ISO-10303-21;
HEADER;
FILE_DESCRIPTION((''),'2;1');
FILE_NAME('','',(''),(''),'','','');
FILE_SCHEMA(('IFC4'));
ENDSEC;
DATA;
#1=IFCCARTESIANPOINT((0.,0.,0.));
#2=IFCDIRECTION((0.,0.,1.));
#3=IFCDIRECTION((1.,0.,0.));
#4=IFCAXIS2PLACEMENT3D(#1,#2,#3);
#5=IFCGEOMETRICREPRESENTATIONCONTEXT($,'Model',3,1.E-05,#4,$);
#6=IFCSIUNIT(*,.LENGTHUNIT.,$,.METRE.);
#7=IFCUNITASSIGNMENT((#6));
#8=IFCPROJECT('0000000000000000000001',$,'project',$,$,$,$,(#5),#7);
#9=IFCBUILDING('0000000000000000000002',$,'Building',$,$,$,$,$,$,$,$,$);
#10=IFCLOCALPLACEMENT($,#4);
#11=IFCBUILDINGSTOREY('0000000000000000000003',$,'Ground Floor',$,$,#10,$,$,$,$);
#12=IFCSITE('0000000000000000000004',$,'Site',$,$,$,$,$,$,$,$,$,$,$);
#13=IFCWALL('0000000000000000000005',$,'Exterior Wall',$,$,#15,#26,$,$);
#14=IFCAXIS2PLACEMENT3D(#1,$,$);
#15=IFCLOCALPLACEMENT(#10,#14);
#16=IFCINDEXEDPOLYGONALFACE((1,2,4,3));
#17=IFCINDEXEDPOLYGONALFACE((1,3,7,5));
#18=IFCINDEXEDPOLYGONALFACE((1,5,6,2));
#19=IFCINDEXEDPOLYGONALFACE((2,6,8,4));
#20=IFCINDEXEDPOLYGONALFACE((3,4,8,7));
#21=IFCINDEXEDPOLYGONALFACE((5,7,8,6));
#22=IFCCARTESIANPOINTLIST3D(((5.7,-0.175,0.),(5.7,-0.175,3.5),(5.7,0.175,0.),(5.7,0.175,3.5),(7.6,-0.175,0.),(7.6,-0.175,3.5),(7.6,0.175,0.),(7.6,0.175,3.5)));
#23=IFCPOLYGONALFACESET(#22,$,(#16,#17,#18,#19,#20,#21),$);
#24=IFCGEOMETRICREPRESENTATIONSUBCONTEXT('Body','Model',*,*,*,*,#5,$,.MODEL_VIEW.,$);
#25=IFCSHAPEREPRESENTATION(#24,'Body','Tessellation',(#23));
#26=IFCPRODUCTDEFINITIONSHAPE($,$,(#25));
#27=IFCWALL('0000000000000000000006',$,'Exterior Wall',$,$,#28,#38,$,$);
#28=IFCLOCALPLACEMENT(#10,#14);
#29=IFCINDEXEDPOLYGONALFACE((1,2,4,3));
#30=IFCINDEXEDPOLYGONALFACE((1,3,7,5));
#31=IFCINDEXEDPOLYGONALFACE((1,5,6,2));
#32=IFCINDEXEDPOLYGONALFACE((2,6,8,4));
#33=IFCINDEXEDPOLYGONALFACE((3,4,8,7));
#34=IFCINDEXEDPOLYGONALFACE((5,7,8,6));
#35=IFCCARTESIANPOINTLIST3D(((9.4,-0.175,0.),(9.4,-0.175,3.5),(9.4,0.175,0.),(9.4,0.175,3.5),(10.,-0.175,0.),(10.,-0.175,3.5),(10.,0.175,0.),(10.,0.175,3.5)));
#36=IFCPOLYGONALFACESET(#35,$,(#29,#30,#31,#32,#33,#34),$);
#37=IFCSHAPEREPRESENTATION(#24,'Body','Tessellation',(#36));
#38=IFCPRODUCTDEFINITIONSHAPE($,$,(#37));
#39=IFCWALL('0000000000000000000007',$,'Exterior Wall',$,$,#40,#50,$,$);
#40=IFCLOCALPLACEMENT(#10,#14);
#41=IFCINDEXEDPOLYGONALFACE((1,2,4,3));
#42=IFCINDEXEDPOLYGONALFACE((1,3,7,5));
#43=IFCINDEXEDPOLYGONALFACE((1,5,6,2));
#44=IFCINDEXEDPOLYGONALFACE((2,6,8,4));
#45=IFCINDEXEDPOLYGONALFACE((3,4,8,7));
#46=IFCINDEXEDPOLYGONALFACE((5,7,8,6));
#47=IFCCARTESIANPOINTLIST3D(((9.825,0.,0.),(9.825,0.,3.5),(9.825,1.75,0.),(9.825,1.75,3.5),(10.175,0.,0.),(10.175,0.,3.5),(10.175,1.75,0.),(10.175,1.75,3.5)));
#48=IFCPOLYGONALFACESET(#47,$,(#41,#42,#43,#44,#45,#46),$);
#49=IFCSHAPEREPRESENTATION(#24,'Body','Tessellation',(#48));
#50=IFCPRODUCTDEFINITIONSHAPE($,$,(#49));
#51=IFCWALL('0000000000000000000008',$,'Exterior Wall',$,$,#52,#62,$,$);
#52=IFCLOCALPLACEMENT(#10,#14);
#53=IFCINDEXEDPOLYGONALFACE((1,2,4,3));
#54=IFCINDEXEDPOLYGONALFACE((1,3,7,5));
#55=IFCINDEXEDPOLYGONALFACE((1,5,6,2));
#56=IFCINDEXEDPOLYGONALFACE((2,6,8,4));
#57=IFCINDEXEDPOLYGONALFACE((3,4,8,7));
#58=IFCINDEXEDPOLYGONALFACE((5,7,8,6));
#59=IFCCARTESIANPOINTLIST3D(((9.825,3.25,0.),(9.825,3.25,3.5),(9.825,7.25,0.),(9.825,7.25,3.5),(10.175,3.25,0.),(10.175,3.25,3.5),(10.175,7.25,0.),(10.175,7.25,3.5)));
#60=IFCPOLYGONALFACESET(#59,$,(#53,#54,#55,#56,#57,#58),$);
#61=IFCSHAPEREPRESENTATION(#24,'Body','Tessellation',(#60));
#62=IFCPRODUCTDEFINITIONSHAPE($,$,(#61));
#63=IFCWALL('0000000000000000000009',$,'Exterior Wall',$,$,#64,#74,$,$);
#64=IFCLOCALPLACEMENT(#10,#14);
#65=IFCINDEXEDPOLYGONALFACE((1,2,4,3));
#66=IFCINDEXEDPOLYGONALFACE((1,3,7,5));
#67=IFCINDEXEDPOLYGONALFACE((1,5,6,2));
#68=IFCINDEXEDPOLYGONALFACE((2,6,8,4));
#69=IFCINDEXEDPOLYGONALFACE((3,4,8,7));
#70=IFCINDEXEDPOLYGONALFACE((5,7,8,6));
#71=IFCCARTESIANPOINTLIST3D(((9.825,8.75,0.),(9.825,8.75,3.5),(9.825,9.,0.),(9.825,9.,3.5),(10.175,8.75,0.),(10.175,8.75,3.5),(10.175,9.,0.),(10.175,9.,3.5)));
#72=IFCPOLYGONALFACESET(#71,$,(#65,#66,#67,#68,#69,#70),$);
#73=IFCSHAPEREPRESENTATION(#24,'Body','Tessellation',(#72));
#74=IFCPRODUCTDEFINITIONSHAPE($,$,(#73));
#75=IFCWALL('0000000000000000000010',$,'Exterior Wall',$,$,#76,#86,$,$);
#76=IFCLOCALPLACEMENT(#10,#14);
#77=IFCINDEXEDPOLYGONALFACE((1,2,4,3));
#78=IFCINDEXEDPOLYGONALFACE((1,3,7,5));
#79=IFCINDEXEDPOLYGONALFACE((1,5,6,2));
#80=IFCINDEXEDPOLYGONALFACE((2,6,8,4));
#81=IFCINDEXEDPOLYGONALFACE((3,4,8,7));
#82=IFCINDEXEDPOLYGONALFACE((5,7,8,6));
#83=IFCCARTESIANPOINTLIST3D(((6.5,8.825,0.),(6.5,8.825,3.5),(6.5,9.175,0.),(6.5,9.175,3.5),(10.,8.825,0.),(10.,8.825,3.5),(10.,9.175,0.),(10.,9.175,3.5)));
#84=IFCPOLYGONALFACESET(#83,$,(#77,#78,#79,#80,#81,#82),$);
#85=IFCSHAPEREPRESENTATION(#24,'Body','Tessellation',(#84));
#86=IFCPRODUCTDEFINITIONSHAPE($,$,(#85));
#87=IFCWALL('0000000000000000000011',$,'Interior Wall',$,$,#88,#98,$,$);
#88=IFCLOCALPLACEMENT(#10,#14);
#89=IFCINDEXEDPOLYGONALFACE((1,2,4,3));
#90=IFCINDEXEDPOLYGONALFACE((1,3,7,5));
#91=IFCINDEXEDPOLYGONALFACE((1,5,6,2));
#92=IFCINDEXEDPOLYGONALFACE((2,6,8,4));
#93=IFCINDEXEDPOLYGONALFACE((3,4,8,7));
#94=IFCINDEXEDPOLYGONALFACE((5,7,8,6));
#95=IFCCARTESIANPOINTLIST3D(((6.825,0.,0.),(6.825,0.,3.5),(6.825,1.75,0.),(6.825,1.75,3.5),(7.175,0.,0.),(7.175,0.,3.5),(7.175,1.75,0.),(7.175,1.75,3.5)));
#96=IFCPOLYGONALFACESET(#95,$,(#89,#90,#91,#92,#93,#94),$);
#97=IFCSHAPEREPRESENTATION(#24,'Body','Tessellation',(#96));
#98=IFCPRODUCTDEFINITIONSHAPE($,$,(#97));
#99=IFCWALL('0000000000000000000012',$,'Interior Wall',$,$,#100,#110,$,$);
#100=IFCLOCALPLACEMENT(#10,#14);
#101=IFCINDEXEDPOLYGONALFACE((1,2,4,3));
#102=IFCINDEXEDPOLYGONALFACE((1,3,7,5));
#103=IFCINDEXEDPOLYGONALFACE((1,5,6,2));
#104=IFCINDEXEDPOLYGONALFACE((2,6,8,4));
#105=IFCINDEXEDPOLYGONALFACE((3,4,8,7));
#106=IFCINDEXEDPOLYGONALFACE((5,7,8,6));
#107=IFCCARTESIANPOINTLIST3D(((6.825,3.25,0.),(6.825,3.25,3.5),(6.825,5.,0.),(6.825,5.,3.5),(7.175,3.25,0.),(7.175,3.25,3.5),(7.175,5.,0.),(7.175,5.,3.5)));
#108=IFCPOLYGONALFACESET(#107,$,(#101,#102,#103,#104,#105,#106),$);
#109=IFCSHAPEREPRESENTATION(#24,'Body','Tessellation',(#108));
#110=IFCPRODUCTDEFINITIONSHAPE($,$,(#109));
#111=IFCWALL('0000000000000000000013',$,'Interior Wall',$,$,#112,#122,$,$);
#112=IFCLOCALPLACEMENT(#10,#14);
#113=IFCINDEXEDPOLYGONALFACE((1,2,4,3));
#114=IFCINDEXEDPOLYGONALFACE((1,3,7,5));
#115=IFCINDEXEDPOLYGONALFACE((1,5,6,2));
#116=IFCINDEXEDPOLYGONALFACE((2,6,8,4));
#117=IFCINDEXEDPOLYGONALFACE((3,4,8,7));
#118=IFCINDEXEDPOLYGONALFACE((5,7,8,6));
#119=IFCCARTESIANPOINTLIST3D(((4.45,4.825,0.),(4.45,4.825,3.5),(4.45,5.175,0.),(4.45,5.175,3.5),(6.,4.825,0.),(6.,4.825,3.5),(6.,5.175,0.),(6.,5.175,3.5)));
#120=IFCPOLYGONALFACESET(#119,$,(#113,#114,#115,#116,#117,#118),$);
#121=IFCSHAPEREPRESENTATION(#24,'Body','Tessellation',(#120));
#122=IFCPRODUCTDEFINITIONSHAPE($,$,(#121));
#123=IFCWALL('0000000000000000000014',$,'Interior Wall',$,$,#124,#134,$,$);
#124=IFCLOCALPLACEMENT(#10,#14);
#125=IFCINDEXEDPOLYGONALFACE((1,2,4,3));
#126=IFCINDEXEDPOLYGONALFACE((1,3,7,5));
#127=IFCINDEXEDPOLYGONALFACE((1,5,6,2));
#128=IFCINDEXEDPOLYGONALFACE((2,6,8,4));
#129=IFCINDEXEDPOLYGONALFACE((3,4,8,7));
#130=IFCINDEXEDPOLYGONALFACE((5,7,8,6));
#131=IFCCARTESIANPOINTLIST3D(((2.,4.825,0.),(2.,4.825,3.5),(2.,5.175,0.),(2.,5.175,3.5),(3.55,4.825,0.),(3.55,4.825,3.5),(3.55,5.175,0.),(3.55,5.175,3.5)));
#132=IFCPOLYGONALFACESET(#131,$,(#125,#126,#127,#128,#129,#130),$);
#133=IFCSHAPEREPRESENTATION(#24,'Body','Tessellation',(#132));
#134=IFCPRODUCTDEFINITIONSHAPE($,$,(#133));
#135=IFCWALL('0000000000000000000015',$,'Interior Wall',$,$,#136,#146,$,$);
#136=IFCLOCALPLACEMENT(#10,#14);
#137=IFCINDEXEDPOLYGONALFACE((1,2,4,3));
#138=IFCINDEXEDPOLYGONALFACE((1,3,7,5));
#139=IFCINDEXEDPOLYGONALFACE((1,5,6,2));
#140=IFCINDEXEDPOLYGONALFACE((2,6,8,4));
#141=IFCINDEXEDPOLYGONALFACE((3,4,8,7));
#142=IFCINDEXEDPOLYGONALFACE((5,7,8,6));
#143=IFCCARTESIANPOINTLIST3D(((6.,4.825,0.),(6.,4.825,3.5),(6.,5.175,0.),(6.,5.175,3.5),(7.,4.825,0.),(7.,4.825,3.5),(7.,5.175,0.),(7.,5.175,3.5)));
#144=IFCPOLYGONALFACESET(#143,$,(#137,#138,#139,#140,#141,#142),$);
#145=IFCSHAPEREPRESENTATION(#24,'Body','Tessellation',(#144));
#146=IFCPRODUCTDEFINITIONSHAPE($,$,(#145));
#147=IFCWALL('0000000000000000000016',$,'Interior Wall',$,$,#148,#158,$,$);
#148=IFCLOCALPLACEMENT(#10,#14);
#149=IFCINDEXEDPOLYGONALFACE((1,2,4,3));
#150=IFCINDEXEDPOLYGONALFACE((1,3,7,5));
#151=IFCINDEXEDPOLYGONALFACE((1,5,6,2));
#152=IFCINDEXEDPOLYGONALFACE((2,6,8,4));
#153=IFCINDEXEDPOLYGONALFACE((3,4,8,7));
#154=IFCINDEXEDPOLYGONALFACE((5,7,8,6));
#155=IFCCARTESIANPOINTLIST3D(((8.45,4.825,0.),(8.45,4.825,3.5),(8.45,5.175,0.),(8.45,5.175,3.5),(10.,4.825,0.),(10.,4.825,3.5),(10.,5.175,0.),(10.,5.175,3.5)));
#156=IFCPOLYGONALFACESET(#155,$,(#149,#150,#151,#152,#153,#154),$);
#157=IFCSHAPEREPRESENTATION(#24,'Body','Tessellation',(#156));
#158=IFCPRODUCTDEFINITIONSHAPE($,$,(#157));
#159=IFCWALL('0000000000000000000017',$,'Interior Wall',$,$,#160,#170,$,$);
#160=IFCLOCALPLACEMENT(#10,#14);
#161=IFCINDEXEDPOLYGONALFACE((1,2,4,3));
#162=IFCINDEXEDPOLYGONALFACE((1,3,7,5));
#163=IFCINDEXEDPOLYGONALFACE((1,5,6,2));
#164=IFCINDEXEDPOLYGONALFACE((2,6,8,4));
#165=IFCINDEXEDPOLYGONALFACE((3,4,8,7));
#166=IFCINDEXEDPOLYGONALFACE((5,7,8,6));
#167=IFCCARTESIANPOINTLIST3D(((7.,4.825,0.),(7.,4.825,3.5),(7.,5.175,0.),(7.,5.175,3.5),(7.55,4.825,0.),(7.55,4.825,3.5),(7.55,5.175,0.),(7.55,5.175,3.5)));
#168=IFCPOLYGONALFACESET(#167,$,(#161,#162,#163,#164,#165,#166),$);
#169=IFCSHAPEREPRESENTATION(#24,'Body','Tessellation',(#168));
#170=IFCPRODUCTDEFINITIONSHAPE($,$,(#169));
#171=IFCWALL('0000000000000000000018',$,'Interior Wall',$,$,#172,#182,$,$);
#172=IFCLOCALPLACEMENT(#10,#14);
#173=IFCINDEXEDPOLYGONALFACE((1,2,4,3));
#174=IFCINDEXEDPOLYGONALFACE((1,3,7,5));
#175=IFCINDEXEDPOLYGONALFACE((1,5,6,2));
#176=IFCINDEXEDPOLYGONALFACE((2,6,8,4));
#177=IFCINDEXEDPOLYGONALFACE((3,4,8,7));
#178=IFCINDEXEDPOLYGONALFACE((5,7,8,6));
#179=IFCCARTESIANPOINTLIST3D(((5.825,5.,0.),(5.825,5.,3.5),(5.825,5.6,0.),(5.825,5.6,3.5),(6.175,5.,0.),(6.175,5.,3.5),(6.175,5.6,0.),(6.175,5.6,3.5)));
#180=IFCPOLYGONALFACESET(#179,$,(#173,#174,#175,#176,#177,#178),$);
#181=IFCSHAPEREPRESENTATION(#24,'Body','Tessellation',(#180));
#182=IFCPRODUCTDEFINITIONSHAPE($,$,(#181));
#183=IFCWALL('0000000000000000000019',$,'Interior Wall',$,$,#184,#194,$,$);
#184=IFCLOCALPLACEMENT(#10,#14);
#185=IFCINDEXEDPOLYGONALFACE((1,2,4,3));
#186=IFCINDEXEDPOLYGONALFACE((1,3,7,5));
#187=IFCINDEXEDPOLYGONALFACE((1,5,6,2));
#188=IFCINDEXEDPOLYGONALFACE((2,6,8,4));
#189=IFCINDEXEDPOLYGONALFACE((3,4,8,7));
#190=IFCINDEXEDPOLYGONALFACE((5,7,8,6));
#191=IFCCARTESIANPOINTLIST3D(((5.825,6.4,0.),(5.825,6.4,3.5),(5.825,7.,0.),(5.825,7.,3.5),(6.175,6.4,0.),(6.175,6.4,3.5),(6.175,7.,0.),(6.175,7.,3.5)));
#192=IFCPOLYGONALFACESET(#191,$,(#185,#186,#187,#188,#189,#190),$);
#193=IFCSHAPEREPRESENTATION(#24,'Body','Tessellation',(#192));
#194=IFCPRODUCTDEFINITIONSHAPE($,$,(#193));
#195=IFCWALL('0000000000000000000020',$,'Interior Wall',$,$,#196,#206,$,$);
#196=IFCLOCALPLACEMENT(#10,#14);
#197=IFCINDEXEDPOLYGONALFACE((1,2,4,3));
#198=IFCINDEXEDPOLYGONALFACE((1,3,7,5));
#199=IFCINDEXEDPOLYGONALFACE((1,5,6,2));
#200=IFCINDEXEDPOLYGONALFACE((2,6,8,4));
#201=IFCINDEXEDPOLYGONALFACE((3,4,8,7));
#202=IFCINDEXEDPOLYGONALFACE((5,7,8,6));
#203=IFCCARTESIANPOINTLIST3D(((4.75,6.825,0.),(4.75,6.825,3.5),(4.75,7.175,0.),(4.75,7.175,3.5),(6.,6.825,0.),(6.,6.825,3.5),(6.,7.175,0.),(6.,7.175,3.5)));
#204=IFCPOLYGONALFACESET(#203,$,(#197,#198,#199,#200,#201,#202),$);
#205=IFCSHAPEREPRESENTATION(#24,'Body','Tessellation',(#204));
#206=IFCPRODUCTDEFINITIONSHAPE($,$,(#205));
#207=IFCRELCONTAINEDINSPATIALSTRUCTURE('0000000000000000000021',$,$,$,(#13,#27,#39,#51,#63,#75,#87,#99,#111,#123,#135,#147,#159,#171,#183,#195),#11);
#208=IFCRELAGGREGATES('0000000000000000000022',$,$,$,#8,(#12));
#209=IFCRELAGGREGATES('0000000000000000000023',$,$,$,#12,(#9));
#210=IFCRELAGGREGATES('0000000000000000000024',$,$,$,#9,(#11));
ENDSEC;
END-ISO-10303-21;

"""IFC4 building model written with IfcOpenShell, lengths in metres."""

from ifc_helpers import new_model, si_unit, frame, origin_with_axes, place, context, subcontext, project, spatial, indexed_curve, outline, extrude, element, save


model = new_model("IFC4")

# Units and contexts
model_context = context("Model", 3, precision=1e-05, world=origin_with_axes())
body_context = subcontext(model_context, "Body", "Model", "MODEL_VIEW")
ifc_project = project(units=[si_unit("LENGTHUNIT", "METRE")], contexts=[model_context])

# Site, building, storey
site = spatial("IfcSite", under=ifc_project, Name="Site")
building = spatial("IfcBuilding", under=site, Name="Building")
storey_placement = place(None, origin_with_axes())
storey = spatial("IfcBuildingStorey", under=building, at=storey_placement, Name="Ground Floor")

# Walls
wall_1_placement = place(storey_placement, frame((5.7, 0.0, 0.0), z_axis=(0.0, 0.0, 1.0), x_axis=(1.0, 0.0, 0.0)))
element("IfcWall", 1, at=wall_1_placement, inside=storey, Name="Exterior Wall", context=body_context, shape_type="SweptSolid", body=[
    extrude(outline(indexed_curve([(0.0, 0.0), (0.0, 0.35), (1.9, 0.35), (1.9, 0.0), (0.0, 0.0)], self_intersect=False)), frame((0.0, -0.175, 0.0), z_axis=(0.0, 0.0, 1.0), x_axis=(1.0, 0.0, 0.0)), (0.0, 0.0, 1.0), 3.5),
])
wall_2_placement = place(storey_placement, frame((9.4, 0.0, 0.0), z_axis=(0.0, 0.0, 1.0), x_axis=(1.0, 0.0, 0.0)))
element("IfcWall", 2, at=wall_2_placement, inside=storey, Name="Exterior Wall", context=body_context, shape_type="SweptSolid", body=[
    extrude(outline(indexed_curve([(0.0, 0.0), (0.0, 0.35), (0.6, 0.35), (0.6, 0.0), (0.0, 0.0)], self_intersect=False)), frame((0.0, -0.175, 0.0), z_axis=(0.0, 0.0, 1.0), x_axis=(1.0, 0.0, 0.0)), (0.0, 0.0, 1.0), 3.5),
])
wall_3_placement = place(storey_placement, frame((10.0, 0.0, 0.0), z_axis=(0.0, 0.0, 1.0), x_axis=(0.0, 1.0, 0.0)))
element("IfcWall", 3, at=wall_3_placement, inside=storey, Name="Exterior Wall", context=body_context, shape_type="SweptSolid", body=[
    extrude(outline(indexed_curve([(0.0, 0.0), (0.0, 0.35), (1.75, 0.35), (1.75, 0.0), (0.0, 0.0)], self_intersect=False)), frame((0.0, -0.175, 0.0), z_axis=(0.0, 0.0, 1.0), x_axis=(1.0, 0.0, 0.0)), (0.0, 0.0, 1.0), 3.5),
])
wall_4_placement = place(storey_placement, frame((10.0, 3.25, 0.0), z_axis=(0.0, 0.0, 1.0), x_axis=(0.0, 1.0, 0.0)))
element("IfcWall", 4, at=wall_4_placement, inside=storey, Name="Exterior Wall", context=body_context, shape_type="SweptSolid", body=[
    extrude(outline(indexed_curve([(0.0, 0.0), (0.0, 0.35), (4.0, 0.35), (4.0, 0.0), (0.0, 0.0)], self_intersect=False)), frame((0.0, -0.175, 0.0), z_axis=(0.0, 0.0, 1.0), x_axis=(1.0, 0.0, 0.0)), (0.0, 0.0, 1.0), 3.5),
])
wall_5_placement = place(storey_placement, frame((10.0, 8.75, 0.0), z_axis=(0.0, 0.0, 1.0), x_axis=(0.0, 1.0, 0.0)))
element("IfcWall", 5, at=wall_5_placement, inside=storey, Name="Exterior Wall", context=body_context, shape_type="SweptSolid", body=[
    extrude(outline(indexed_curve([(0.0, 0.0), (0.0, 0.35), (0.25, 0.35), (0.25, 0.0), (0.0, 0.0)], self_intersect=False)), frame((0.0, -0.175, 0.0), z_axis=(0.0, 0.0, 1.0), x_axis=(1.0, 0.0, 0.0)), (0.0, 0.0, 1.0), 3.5),
])
wall_6_placement = place(storey_placement, frame((10.0, 9.0, 0.0), z_axis=(0.0, 0.0, 1.0), x_axis=(-1.0, 0.0, 0.0)))
element("IfcWall", 6, at=wall_6_placement, inside=storey, Name="Exterior Wall", context=body_context, shape_type="SweptSolid", body=[
    extrude(outline(indexed_curve([(0.0, 0.0), (0.0, 0.35), (3.5, 0.35), (3.5, 0.0), (0.0, 0.0)], self_intersect=False)), frame((0.0, -0.175, 0.0), z_axis=(0.0, 0.0, 1.0), x_axis=(1.0, 0.0, 0.0)), (0.0, 0.0, 1.0), 3.5),
])
for number, where, z_axis, x_axis, name in (
    (7, (7.0, 0.0, 0.0), (0.0, 0.0, 1.0), (0.0, 1.0, 0.0), "Interior Wall"),
    (8, (7.0, 3.25, 0.0), (0.0, 0.0, 1.0), (0.0, 1.0, 0.0), "Interior Wall"),
):
    element("IfcWall", number, at=place(storey_placement, frame(where, z_axis=z_axis, x_axis=x_axis)), inside=storey, Name=name, context=body_context, shape_type="SweptSolid", body=[
        extrude(outline(indexed_curve([(0.0, 0.0), (0.0, 0.35), (1.75, 0.35), (1.75, 0.0), (0.0, 0.0)], self_intersect=False)), frame((0.0, -0.175, 0.0), z_axis=(0.0, 0.0, 1.0), x_axis=(1.0, 0.0, 0.0)), (0.0, 0.0, 1.0), 3.5),
    ])
for number, where, z_axis, x_axis, name in (
    (9, (6.0, 5.0, 0.0), (0.0, 0.0, 1.0), (-1.0, 0.0, 0.0), "Interior Wall"),
    (10, (3.55, 5.0, 0.0), (0.0, 0.0, 1.0), (-1.0, 0.0, 0.0), "Interior Wall"),
):
    element("IfcWall", number, at=place(storey_placement, frame(where, z_axis=z_axis, x_axis=x_axis)), inside=storey, Name=name, context=body_context, shape_type="SweptSolid", body=[
        extrude(outline(indexed_curve([(0.0, 0.0), (0.0, 0.35), (1.55, 0.35), (1.55, 0.0), (0.0, 0.0)], self_intersect=False)), frame((0.0, -0.175, 0.0), z_axis=(0.0, 0.0, 1.0), x_axis=(1.0, 0.0, 0.0)), (0.0, 0.0, 1.0), 3.5),
    ])
wall_7_placement = place(storey_placement, frame((7.0, 5.0, 0.0), z_axis=(0.0, 0.0, 1.0), x_axis=(-1.0, 0.0, 0.0)))
element("IfcWall", 11, at=wall_7_placement, inside=storey, Name="Interior Wall", context=body_context, shape_type="SweptSolid", body=[
    extrude(outline(indexed_curve([(0.0, 0.0), (0.0, 0.35), (1.0, 0.35), (1.0, 0.0), (0.0, 0.0)], self_intersect=False)), frame((0.0, -0.175, 0.0), z_axis=(0.0, 0.0, 1.0), x_axis=(1.0, 0.0, 0.0)), (0.0, 0.0, 1.0), 3.5),
])
wall_8_placement = place(storey_placement, frame((10.0, 5.0, 0.0), z_axis=(0.0, 0.0, 1.0), x_axis=(-1.0, 0.0, 0.0)))
element("IfcWall", 12, at=wall_8_placement, inside=storey, Name="Interior Wall", context=body_context, shape_type="SweptSolid", body=[
    extrude(outline(indexed_curve([(0.0, 0.0), (0.0, 0.35), (1.55, 0.35), (1.55, 0.0), (0.0, 0.0)], self_intersect=False)), frame((0.0, -0.175, 0.0), z_axis=(0.0, 0.0, 1.0), x_axis=(1.0, 0.0, 0.0)), (0.0, 0.0, 1.0), 3.5),
])
wall_9_placement = place(storey_placement, frame((7.55, 5.0, 0.0), z_axis=(0.0, 0.0, 1.0), x_axis=(-1.0, 0.0, 0.0)))
element("IfcWall", 13, at=wall_9_placement, inside=storey, Name="Interior Wall", context=body_context, shape_type="SweptSolid", body=[
    extrude(outline(indexed_curve([(0.0, 0.0), (0.0, 0.35), (0.55, 0.35), (0.55, 0.0), (0.0, 0.0)], self_intersect=False)), frame((0.0, -0.175, 0.0), z_axis=(0.0, 0.0, 1.0), x_axis=(1.0, 0.0, 0.0)), (0.0, 0.0, 1.0), 3.5),
])
for number, where, z_axis, x_axis, name in (
    (14, (6.0, 5.0, 0.0), (0.0, 0.0, 1.0), (0.0, 1.0, 0.0), "Interior Wall"),
    (15, (6.0, 6.4, 0.0), (0.0, 0.0, 1.0), (0.0, 1.0, 0.0), "Interior Wall"),
):
    element("IfcWall", number, at=place(storey_placement, frame(where, z_axis=z_axis, x_axis=x_axis)), inside=storey, Name=name, context=body_context, shape_type="SweptSolid", body=[
        extrude(outline(indexed_curve([(0.0, 0.0), (0.0, 0.35), (0.6, 0.35), (0.6, 0.0), (0.0, 0.0)], self_intersect=False)), frame((0.0, -0.175, 0.0), z_axis=(0.0, 0.0, 1.0), x_axis=(1.0, 0.0, 0.0)), (0.0, 0.0, 1.0), 3.5),
    ])
for number, where, z_axis, x_axis, name in (
    (16, (6.0, 7.0, 0.0), (0.0, 0.0, 1.0), (-1.0, 0.0, 0.0), "Interior Wall"),
):
    element("IfcWall", number, at=place(storey_placement, frame(where, z_axis=z_axis, x_axis=x_axis)), inside=storey, Name=name, context=body_context, shape_type="SweptSolid", body=[
        extrude(outline(indexed_curve([(0.0, 0.0), (0.0, 0.35), (1.25, 0.35), (1.25, 0.0), (0.0, 0.0)], self_intersect=False)), frame((0.0, -0.175, 0.0), z_axis=(0.0, 0.0, 1.0), x_axis=(1.0, 0.0, 0.0)), (0.0, 0.0, 1.0), 3.5),
    ])

save(model, "model.ifc")
